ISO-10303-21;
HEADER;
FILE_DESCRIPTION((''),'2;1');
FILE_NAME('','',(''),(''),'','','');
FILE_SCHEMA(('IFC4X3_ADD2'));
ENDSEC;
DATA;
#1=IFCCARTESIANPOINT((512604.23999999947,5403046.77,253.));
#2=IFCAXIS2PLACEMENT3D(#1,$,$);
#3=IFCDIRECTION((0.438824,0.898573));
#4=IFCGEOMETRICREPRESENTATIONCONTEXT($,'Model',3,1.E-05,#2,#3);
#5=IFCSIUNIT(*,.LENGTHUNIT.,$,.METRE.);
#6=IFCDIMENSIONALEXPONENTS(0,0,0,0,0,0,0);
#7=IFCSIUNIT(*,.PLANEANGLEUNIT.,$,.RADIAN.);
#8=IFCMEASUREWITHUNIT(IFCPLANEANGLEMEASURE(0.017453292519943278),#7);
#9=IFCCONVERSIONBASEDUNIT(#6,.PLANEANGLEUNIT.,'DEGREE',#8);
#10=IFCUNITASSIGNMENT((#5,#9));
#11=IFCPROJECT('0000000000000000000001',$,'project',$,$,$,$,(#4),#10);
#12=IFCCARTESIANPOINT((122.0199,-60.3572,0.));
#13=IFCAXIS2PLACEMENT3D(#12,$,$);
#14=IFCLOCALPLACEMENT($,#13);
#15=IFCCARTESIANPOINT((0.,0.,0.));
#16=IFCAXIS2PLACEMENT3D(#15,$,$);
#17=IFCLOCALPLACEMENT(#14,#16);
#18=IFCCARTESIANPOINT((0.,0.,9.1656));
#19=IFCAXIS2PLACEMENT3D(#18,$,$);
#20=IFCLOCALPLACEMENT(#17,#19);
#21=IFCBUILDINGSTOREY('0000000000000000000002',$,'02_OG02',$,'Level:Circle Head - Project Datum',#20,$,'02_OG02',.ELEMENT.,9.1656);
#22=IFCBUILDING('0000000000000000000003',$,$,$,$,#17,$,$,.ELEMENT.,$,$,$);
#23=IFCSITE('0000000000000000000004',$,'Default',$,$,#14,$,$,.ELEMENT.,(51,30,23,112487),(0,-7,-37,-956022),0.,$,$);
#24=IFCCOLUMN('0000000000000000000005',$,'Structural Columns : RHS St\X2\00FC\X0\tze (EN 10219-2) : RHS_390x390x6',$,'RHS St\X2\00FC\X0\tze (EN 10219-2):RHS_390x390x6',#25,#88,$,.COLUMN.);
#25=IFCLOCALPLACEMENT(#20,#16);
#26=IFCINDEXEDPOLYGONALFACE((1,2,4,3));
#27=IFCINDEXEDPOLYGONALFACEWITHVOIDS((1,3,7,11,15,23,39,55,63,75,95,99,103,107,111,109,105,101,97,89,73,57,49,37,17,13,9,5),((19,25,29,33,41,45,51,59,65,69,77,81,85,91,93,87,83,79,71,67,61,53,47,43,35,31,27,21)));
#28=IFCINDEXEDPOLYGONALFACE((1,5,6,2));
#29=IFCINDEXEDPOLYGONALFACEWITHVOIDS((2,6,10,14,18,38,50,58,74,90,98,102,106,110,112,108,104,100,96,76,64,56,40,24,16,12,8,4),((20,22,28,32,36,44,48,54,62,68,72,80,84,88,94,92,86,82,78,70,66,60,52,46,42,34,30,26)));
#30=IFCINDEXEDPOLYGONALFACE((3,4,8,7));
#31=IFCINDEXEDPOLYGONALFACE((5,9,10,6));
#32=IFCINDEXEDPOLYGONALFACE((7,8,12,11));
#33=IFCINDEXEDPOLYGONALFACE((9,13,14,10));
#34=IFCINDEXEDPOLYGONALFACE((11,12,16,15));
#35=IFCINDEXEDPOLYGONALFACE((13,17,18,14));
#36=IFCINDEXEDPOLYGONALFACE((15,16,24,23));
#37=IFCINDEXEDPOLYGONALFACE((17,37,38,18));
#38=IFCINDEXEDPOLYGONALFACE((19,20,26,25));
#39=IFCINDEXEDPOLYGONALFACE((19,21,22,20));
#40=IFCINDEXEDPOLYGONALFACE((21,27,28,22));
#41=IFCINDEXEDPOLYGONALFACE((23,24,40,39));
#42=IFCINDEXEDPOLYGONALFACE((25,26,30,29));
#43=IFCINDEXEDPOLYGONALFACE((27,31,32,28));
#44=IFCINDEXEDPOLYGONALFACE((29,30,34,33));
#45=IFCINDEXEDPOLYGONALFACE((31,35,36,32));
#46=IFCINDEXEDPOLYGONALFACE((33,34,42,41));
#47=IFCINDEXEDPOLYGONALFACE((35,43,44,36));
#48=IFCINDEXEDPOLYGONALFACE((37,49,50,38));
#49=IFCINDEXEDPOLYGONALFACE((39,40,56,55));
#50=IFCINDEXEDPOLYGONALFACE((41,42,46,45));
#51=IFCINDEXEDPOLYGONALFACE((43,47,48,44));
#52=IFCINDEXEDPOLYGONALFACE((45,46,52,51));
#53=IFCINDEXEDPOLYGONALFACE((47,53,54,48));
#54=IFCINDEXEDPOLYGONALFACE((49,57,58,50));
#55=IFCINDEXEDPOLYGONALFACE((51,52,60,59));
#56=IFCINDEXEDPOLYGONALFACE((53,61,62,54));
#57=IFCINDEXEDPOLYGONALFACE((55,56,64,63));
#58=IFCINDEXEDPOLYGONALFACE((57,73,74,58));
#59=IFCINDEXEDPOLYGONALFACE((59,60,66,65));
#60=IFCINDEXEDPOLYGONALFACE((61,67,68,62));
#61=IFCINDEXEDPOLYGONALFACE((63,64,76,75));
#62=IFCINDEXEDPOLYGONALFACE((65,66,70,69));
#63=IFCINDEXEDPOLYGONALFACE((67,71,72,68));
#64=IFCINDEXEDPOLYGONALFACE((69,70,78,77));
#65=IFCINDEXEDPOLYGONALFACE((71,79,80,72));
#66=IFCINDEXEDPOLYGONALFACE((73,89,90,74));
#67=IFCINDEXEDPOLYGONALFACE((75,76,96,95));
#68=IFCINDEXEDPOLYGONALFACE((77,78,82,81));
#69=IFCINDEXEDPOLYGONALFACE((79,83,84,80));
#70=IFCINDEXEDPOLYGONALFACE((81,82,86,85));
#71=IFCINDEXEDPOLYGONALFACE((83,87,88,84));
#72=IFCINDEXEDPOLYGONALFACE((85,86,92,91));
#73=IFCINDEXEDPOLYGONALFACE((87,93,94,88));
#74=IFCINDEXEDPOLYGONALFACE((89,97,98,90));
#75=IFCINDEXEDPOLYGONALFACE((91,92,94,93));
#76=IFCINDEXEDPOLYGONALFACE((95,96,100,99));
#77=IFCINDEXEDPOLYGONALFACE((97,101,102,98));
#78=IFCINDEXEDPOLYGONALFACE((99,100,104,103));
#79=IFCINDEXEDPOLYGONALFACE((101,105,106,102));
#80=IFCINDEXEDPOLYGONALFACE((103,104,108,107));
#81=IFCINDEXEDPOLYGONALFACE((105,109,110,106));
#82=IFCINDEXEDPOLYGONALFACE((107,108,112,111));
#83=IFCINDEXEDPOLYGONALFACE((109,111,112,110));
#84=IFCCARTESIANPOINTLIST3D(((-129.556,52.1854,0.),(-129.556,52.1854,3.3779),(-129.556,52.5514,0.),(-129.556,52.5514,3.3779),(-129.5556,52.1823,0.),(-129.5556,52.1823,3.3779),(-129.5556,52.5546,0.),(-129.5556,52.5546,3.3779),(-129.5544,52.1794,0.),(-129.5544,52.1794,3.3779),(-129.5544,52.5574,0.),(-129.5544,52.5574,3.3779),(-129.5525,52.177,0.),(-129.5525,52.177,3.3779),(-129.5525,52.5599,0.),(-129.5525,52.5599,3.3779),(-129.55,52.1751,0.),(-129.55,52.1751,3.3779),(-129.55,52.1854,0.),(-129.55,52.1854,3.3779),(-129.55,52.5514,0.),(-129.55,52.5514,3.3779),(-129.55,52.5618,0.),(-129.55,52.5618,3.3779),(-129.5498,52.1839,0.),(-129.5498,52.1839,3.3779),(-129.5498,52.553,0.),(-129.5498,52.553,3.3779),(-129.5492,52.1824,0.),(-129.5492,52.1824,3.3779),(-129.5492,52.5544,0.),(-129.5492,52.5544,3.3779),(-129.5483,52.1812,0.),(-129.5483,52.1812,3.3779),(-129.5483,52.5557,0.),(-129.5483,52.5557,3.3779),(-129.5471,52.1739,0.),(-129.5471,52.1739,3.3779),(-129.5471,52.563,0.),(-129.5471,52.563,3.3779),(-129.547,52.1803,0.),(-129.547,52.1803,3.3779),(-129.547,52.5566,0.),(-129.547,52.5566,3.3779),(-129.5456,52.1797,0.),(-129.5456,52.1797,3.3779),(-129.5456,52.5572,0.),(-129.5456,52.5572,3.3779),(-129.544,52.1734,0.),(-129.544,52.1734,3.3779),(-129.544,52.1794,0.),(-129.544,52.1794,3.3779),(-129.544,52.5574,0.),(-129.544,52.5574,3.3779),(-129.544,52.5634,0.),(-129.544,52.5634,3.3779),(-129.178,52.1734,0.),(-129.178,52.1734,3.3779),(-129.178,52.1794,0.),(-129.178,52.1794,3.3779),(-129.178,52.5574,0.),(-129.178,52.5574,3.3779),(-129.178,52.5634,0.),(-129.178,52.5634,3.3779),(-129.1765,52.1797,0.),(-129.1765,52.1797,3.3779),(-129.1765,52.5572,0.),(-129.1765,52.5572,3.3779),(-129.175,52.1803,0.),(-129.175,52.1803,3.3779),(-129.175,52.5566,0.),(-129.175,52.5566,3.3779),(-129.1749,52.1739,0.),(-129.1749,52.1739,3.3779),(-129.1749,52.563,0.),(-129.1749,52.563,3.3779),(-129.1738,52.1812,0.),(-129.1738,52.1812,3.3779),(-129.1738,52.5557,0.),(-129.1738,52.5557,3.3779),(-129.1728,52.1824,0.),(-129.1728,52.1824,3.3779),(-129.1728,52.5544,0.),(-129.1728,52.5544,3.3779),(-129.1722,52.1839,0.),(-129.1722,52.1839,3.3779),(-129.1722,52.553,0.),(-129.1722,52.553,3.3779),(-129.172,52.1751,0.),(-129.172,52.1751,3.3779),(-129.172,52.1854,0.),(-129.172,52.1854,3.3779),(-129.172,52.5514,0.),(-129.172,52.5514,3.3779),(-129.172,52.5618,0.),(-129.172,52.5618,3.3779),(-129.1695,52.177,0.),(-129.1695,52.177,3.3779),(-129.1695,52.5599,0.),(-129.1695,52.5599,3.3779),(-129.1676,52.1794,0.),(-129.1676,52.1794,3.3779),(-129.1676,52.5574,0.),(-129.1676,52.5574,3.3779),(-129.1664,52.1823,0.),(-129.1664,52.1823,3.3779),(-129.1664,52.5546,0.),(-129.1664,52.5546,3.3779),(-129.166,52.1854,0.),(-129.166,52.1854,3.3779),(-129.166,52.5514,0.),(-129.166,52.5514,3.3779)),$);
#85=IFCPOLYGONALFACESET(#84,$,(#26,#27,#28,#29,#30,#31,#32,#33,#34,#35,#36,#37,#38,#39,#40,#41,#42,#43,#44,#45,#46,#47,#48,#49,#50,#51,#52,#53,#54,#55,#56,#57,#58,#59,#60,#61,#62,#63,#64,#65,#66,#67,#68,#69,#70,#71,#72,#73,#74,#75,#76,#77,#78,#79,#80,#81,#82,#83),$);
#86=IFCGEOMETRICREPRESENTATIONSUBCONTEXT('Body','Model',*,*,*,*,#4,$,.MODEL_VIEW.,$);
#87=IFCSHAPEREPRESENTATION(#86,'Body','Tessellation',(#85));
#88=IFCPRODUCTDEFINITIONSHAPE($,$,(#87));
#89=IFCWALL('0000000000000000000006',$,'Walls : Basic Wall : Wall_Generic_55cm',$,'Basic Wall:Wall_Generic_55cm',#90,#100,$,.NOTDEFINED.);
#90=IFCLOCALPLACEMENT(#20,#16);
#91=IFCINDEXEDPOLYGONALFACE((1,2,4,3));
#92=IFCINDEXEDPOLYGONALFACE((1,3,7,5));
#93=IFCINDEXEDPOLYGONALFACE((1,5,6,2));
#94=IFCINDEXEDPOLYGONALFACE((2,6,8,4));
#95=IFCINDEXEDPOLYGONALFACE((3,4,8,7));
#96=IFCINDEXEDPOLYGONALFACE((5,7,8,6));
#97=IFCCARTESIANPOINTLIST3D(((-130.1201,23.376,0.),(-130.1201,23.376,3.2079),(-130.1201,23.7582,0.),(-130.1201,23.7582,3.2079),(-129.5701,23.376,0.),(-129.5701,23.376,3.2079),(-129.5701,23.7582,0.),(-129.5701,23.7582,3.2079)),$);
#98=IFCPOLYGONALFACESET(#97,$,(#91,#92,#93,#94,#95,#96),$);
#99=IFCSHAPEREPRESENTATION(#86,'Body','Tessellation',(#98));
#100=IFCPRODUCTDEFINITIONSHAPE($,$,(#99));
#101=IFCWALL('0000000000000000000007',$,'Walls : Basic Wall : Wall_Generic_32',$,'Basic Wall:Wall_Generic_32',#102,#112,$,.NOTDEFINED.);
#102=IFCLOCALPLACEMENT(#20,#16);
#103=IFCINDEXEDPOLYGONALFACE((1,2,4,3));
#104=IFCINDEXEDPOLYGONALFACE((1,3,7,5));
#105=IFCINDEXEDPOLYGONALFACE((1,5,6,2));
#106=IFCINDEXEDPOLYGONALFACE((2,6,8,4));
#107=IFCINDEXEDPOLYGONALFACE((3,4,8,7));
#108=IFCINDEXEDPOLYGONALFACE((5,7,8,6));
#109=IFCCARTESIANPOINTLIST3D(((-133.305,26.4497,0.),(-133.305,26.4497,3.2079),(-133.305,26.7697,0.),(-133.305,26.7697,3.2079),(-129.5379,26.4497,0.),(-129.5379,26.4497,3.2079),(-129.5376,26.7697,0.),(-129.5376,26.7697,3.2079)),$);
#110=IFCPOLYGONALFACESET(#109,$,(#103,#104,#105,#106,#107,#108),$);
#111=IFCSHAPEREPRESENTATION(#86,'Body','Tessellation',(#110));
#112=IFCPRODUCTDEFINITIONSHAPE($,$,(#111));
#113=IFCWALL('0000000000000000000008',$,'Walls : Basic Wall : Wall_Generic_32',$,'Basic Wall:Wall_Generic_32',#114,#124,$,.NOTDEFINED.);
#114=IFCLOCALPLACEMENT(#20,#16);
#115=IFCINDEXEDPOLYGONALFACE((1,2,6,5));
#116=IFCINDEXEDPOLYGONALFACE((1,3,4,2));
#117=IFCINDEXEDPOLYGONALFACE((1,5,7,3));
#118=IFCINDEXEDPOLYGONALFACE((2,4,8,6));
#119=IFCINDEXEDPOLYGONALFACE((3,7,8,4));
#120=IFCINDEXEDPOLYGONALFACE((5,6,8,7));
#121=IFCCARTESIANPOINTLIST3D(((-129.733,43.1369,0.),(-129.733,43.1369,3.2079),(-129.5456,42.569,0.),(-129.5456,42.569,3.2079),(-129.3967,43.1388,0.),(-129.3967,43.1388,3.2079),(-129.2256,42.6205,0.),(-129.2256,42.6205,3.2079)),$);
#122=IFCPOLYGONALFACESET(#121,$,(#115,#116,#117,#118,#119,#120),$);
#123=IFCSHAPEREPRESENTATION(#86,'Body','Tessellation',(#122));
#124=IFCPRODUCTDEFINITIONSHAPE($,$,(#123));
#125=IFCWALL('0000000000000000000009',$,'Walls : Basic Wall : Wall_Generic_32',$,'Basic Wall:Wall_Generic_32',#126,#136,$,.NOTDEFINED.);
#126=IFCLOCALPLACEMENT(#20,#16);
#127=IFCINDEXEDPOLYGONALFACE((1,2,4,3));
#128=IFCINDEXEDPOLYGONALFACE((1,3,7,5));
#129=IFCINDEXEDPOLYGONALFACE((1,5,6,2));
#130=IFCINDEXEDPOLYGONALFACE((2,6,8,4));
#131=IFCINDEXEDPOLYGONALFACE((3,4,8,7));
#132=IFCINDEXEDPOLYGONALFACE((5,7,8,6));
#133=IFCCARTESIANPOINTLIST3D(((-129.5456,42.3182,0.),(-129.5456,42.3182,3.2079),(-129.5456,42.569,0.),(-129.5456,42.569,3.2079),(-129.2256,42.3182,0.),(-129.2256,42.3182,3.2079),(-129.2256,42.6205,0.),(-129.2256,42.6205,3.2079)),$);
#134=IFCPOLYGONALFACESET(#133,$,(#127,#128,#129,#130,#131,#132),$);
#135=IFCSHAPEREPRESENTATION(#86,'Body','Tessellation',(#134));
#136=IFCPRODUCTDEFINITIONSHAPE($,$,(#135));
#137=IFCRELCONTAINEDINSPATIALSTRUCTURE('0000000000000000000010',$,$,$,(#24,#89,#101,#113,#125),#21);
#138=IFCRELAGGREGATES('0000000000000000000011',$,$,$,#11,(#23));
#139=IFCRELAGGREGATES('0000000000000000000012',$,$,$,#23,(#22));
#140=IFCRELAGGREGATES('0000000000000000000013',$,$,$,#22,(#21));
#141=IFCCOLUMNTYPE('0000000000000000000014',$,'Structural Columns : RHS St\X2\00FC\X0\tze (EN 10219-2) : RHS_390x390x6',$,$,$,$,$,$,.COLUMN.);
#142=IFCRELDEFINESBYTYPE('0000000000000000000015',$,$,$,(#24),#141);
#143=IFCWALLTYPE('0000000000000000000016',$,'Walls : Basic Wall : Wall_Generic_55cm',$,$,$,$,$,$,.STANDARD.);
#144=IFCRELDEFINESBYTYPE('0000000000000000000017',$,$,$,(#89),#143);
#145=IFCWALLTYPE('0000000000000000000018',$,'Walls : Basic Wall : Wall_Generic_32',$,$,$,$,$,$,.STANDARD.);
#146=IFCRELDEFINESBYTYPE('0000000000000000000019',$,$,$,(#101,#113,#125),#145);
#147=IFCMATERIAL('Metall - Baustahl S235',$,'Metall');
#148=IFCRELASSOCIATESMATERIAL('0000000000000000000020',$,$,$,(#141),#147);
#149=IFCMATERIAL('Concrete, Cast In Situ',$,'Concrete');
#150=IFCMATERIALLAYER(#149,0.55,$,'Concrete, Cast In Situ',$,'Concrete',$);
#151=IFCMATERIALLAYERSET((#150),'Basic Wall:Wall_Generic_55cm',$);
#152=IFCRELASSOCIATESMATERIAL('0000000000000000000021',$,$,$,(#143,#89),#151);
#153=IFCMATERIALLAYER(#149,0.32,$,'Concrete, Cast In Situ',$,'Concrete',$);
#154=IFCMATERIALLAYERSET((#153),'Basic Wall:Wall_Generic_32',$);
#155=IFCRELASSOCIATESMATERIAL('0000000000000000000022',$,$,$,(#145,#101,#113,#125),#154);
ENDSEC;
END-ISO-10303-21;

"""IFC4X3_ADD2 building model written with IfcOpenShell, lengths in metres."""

from ifc_helpers import new_model, entity, si_unit, converted_unit, direction, frame, frame_2d, origin, place, context, subcontext, project, spatial, polyline, circle_curve, parameter, trimmed, segment, composite_curve, rectangle, outline, extrude, clip, bounded_halfspace, source, transform, mapped, material, layer, layer_set, material_profile, profile_set, type_object, type_shapes, element, save


model = new_model("IFC4X3_ADD2")

# Units and contexts
model_context = context("Model", 3, precision=1e-05, world=frame((512604.23999999947, 5403046.77, 253.0)), true_north=direction((0.438824, 0.898573)))
body_context = subcontext(model_context, "Body", "Model", "MODEL_VIEW")
ifc_project = project(units=[si_unit("LENGTHUNIT", "METRE"), converted_unit("PLANEANGLEUNIT", "DEGREE", entity("IfcPlaneAngleMeasure", 0.017453292519943278), si_unit("PLANEANGLEUNIT", "RADIAN"), dimensions=[0, 0, 0, 0, 0, 0, 0])], contexts=[model_context])

# Site, building, storey
site_placement = place(None, frame((122.0199, -60.3572, 0.0)))
site = spatial("IfcSite", under=ifc_project, at=site_placement, Name="Default", CompositionType="ELEMENT", RefLatitude=(51, 30, 23, 112487), RefLongitude=(0, -7, -37, -956022), RefElevation=0.0)
building_placement = place(site_placement, origin())
building = spatial("IfcBuilding", under=site, at=building_placement, CompositionType="ELEMENT")
storey_placement = place(building_placement, frame((0.0, 0.0, 9.1656)))
storey = spatial("IfcBuildingStorey", under=building, at=storey_placement, Name="02_OG02", ObjectType="Level:Circle Head - Project Datum", LongName="02_OG02", CompositionType="ELEMENT", Elevation=9.1656)

# Column
ifc_material_1 = material(Name="Metall - Baustahl S235", Category="Metall")
ifc_material_profile = material_profile(ifc_material_1, outline(composite_curve([segment(polyline([(-0.183, -0.195), (0.183, -0.195)]), True, "CONTINUOUS"), segment(trimmed(circle_curve(frame_2d((0.183, -0.183), x_axis=(-1.0, 0.0)), 0.012), [parameter(90.0)], [parameter(180.0)], True, "PARAMETER"), True, "CONTINUOUS"), segment(polyline([(0.195, -0.183), (0.195, 0.183)]), True, "CONTINUOUS"), segment(trimmed(circle_curve(frame_2d((0.183, 0.183), x_axis=(-1.0, 0.0)), 0.012), [parameter(180.0)], [parameter(270.0)], True, "PARAMETER"), True, "CONTINUOUS"), segment(polyline([(0.183, 0.195), (-0.183, 0.195)]), True, "CONTINUOUS"), segment(trimmed(circle_curve(frame_2d((-0.183, 0.183), x_axis=(-1.0, 0.0)), 0.012), [parameter(270.0)], [parameter(360.0)], True, "PARAMETER"), True, "CONTINUOUS"), segment(polyline([(-0.195, 0.183), (-0.195, -0.183)]), True, "CONTINUOUS"), segment(trimmed(circle_curve(frame_2d((-0.183, -0.183), x_axis=(-1.0, 0.0)), 0.012), [parameter(360.0)], [parameter(90.0)], True, "PARAMETER"), True, "CONTINUOUS")], self_intersect=False), holes=[composite_curve([segment(trimmed(circle_curve(frame_2d((-0.183, -0.183), x_axis=(-1.0, 0.0)), 0.006), [parameter(0.0)], [parameter(90.0)], True, "PARAMETER"), False, "CONTINUOUS"), segment(polyline([(-0.189, -0.183), (-0.189, 0.183)]), True, "CONTINUOUS"), segment(trimmed(circle_curve(frame_2d((-0.183, 0.183), x_axis=(-1.0, 0.0)), 0.006), [parameter(270.0)], [parameter(0.0)], True, "PARAMETER"), False, "CONTINUOUS"), segment(polyline([(-0.183, 0.189), (0.183, 0.189)]), True, "CONTINUOUS"), segment(trimmed(circle_curve(frame_2d((0.183, 0.183), x_axis=(-1.0, 0.0)), 0.006), [parameter(180.0)], [parameter(270.0)], True, "PARAMETER"), False, "CONTINUOUS"), segment(polyline([(0.189, 0.183), (0.189, -0.183)]), True, "CONTINUOUS"), segment(trimmed(circle_curve(frame_2d((0.183, -0.183), x_axis=(-1.0, 0.0)), 0.006), [parameter(90.0)], [parameter(180.0)], True, "PARAMETER"), False, "CONTINUOUS"), segment(polyline([(0.183, -0.189), (-0.183, -0.189)]), True, "CONTINUOUS")], self_intersect=False)]), Name="RHS_390x390x6")
ifc_profile_set = profile_set([ifc_material_profile], Name="RHS_390x390x6")
column_type_1 = type_object("IfcColumnType", Name="Structural Columns : RHS Stütze (EN 10219-2) : RHS_390x390x6", PredefinedType="COLUMN", material=ifc_profile_set)
shared_shape_1 = source(origin(), body_context, "Body", "SweptSolid", [
    extrude(outline(composite_curve([segment(polyline([(-0.183, -0.195), (0.183, -0.195)]), True, "CONTINUOUS"), segment(trimmed(circle_curve(frame_2d((0.183, -0.183), x_axis=(-1.0, 0.0)), 0.012), [parameter(90.0)], [parameter(180.0)], True, "PARAMETER"), True, "CONTINUOUS"), segment(polyline([(0.195, -0.183), (0.195, 0.183)]), True, "CONTINUOUS"), segment(trimmed(circle_curve(frame_2d((0.183, 0.183), x_axis=(-1.0, 0.0)), 0.012), [parameter(180.0)], [parameter(270.0)], True, "PARAMETER"), True, "CONTINUOUS"), segment(polyline([(0.183, 0.195), (-0.183, 0.195)]), True, "CONTINUOUS"), segment(trimmed(circle_curve(frame_2d((-0.183, 0.183), x_axis=(-1.0, 0.0)), 0.012), [parameter(270.0)], [parameter(360.0)], True, "PARAMETER"), True, "CONTINUOUS"), segment(polyline([(-0.195, 0.183), (-0.195, -0.183)]), True, "CONTINUOUS"), segment(trimmed(circle_curve(frame_2d((-0.183, -0.183), x_axis=(-1.0, 0.0)), 0.012), [parameter(360.0)], [parameter(90.0)], True, "PARAMETER"), True, "CONTINUOUS")], self_intersect=False), holes=[composite_curve([segment(trimmed(circle_curve(frame_2d((-0.183, -0.183), x_axis=(-1.0, 0.0)), 0.006), [parameter(0.0)], [parameter(90.0)], True, "PARAMETER"), False, "CONTINUOUS"), segment(polyline([(-0.189, -0.183), (-0.189, 0.183)]), True, "CONTINUOUS"), segment(trimmed(circle_curve(frame_2d((-0.183, 0.183), x_axis=(-1.0, 0.0)), 0.006), [parameter(270.0)], [parameter(0.0)], True, "PARAMETER"), False, "CONTINUOUS"), segment(polyline([(-0.183, 0.189), (0.183, 0.189)]), True, "CONTINUOUS"), segment(trimmed(circle_curve(frame_2d((0.183, 0.183), x_axis=(-1.0, 0.0)), 0.006), [parameter(180.0)], [parameter(270.0)], True, "PARAMETER"), False, "CONTINUOUS"), segment(polyline([(0.189, 0.183), (0.189, -0.183)]), True, "CONTINUOUS"), segment(trimmed(circle_curve(frame_2d((0.183, -0.183), x_axis=(-1.0, 0.0)), 0.006), [parameter(90.0)], [parameter(180.0)], True, "PARAMETER"), False, "CONTINUOUS"), segment(polyline([(0.183, -0.189), (-0.183, -0.189)]), True, "CONTINUOUS")], self_intersect=False)]), frame((0.0, 0.0, 9.1656), z_axis=(0.0, 0.0, 1.0), x_axis=(-1.0, 0.0, 0.0)), (0.0, 0.0, 1.0), 3.3779),
])
type_shapes(column_type_1, [shared_shape_1])
column_1_placement = place(storey_placement, frame((-129.361, 52.3684, -9.1656)))
element("IfcColumn", 1, at=column_1_placement, inside=storey, type_object=column_type_1, Name="Structural Columns : RHS Stütze (EN 10219-2) : RHS_390x390x6", ObjectType="RHS Stütze (EN 10219-2):RHS_390x390x6", PredefinedType="COLUMN", context=body_context, shape_type="MappedRepresentation", body=[
    mapped(shared_shape_1, transform((0.0, 0.0, 0.0), scale=1.0)),
])

# Walls
ifc_material_2 = material(Name="Concrete, Cast In Situ", Category="Concrete")
ifc_layer_1 = layer(ifc_material_2, 0.55, Name="Concrete, Cast In Situ", Category="Concrete")
ifc_layer_set_1 = layer_set([ifc_layer_1], Name="Basic Wall:Wall_Generic_55cm")
wall_type_1 = type_object("IfcWallType", Name="Walls : Basic Wall : Wall_Generic_55cm", PredefinedType="STANDARD", material=ifc_layer_set_1)
wall_1_placement = place(storey_placement, frame((-129.8451, 23.7582, 0.0), z_axis=(0.0, 0.0, 1.0), x_axis=(0.0, -1.0, 0.0)))
element("IfcWall", 2, at=wall_1_placement, inside=storey, type_object=wall_type_1, material=ifc_layer_set_1, Name="Walls : Basic Wall : Wall_Generic_55cm", ObjectType="Basic Wall:Wall_Generic_55cm", PredefinedType="NOTDEFINED", context=body_context, shape_type="Clipping", body=[
    clip(extrude(rectangle(XDim=0.3822, YDim=0.55, at=frame_2d((0.1911, 0.0), x_axis=(-1.0, 0.0))), origin(), (0.0, 0.0, 1.0), 3.2079), bounded_halfspace(frame((0.0, -0.275, 3.2079), z_axis=(0.0, 0.0, -1.0), x_axis=(1.0, -0.000002, 0.0)), True, frame((0.0, -0.275, 3.2079)), polyline([(0.0, 0.0), (0.1422, 0.0), (0.3822, 0.0), (0.3822, 0.55), (0.0, 0.55), (0.0, 0.0)]))),
])
ifc_layer_2 = layer(ifc_material_2, 0.32, Name="Concrete, Cast In Situ", Category="Concrete")
ifc_layer_set_2 = layer_set([ifc_layer_2], Name="Basic Wall:Wall_Generic_32")
wall_type_2 = type_object("IfcWallType", Name="Walls : Basic Wall : Wall_Generic_32", PredefinedType="STANDARD", material=ifc_layer_set_2)
wall_2_placement = place(storey_placement, frame((-133.305, 26.6097, 0.0)))
element("IfcWall", 3, at=wall_2_placement, inside=storey, type_object=wall_type_2, material=ifc_layer_set_2, Name="Walls : Basic Wall : Wall_Generic_32", ObjectType="Basic Wall:Wall_Generic_32", PredefinedType="NOTDEFINED", context=body_context, shape_type="Clipping", body=[
    clip(extrude(outline(polyline([(3.7671, -0.16), (3.7674, 0.16), (3.4674, 0.16), (0.0, 0.16), (0.0, -0.16), (3.7671, -0.16)])), origin(), (0.0, 0.0, 1.0), 3.2079), bounded_halfspace(frame((0.0, -0.16, 3.2079), z_axis=(0.0, 0.0, -1.0), x_axis=(-0.000002, -1.0, 0.0)), True, frame((0.0, -0.16, 3.2079)), polyline([(0.0, 0.0), (3.7671, 0.0), (3.7674, 0.32), (3.4674, 0.32), (0.0, 0.32), (0.0, 0.0)]))),
])

# Walls
wall_3_placement = place(storey_placement, frame((-129.5811, 43.187, 0.0), z_axis=(0.0, 0.0, 1.0), x_axis=(0.313355, -0.949636, 0.0)))
element("IfcWall", 4, at=wall_3_placement, inside=storey, type_object=wall_type_2, material=ifc_layer_set_2, Name="Walls : Basic Wall : Wall_Generic_32", ObjectType="Basic Wall:Wall_Generic_32", PredefinedType="NOTDEFINED", context=body_context, shape_type="Clipping", body=[
    clip(extrude(outline(polyline([(0.598, -0.16), (0.6494, 0.16), (0.1036, 0.16), (0.0, -0.16), (0.3363, -0.16), (0.598, -0.16)])), origin(), (0.0, 0.0, 1.0), 3.2079), bounded_halfspace(frame((0.0, -0.16, 3.2079), z_axis=(0.0, 0.0, -1.0), x_axis=(0.949636, -0.313357, 0.0)), True, frame((0.0, -0.16, 3.2079)), polyline([(0.0, 0.0), (0.3363, 0.0), (0.598, 0.0), (0.6494, 0.32), (0.1036, 0.32), (0.0, 0.0)]))),
])
wall_4_placement = place(storey_placement, frame((-129.3856, 42.6205, 0.0), z_axis=(0.0, 0.0, 1.0), x_axis=(0.0, -1.0, 0.0)))
element("IfcWall", 5, at=wall_4_placement, inside=storey, type_object=wall_type_2, material=ifc_layer_set_2, Name="Walls : Basic Wall : Wall_Generic_32", ObjectType="Basic Wall:Wall_Generic_32", PredefinedType="NOTDEFINED", context=body_context, shape_type="Clipping", body=[
    clip(extrude(outline(polyline([(0.3023, -0.16), (0.3023, 0.16), (0.2423, 0.16), (0.0, 0.16), (0.0514, -0.16), (0.3023, -0.16)])), origin(), (0.0, 0.0, 1.0), 3.2079), bounded_halfspace(frame((0.0514, -0.16, 3.2079), z_axis=(0.0, 0.0, -1.0), x_axis=(1.0, -0.000002, 0.0)), True, frame((0.0514, -0.16, 3.2079)), polyline([(0.0, 0.0), (0.2508, 0.0), (0.2508, 0.32), (0.1908, 0.32), (-0.0514, 0.32), (0.0, 0.0)]))),
])

save(model, "model.ifc")
